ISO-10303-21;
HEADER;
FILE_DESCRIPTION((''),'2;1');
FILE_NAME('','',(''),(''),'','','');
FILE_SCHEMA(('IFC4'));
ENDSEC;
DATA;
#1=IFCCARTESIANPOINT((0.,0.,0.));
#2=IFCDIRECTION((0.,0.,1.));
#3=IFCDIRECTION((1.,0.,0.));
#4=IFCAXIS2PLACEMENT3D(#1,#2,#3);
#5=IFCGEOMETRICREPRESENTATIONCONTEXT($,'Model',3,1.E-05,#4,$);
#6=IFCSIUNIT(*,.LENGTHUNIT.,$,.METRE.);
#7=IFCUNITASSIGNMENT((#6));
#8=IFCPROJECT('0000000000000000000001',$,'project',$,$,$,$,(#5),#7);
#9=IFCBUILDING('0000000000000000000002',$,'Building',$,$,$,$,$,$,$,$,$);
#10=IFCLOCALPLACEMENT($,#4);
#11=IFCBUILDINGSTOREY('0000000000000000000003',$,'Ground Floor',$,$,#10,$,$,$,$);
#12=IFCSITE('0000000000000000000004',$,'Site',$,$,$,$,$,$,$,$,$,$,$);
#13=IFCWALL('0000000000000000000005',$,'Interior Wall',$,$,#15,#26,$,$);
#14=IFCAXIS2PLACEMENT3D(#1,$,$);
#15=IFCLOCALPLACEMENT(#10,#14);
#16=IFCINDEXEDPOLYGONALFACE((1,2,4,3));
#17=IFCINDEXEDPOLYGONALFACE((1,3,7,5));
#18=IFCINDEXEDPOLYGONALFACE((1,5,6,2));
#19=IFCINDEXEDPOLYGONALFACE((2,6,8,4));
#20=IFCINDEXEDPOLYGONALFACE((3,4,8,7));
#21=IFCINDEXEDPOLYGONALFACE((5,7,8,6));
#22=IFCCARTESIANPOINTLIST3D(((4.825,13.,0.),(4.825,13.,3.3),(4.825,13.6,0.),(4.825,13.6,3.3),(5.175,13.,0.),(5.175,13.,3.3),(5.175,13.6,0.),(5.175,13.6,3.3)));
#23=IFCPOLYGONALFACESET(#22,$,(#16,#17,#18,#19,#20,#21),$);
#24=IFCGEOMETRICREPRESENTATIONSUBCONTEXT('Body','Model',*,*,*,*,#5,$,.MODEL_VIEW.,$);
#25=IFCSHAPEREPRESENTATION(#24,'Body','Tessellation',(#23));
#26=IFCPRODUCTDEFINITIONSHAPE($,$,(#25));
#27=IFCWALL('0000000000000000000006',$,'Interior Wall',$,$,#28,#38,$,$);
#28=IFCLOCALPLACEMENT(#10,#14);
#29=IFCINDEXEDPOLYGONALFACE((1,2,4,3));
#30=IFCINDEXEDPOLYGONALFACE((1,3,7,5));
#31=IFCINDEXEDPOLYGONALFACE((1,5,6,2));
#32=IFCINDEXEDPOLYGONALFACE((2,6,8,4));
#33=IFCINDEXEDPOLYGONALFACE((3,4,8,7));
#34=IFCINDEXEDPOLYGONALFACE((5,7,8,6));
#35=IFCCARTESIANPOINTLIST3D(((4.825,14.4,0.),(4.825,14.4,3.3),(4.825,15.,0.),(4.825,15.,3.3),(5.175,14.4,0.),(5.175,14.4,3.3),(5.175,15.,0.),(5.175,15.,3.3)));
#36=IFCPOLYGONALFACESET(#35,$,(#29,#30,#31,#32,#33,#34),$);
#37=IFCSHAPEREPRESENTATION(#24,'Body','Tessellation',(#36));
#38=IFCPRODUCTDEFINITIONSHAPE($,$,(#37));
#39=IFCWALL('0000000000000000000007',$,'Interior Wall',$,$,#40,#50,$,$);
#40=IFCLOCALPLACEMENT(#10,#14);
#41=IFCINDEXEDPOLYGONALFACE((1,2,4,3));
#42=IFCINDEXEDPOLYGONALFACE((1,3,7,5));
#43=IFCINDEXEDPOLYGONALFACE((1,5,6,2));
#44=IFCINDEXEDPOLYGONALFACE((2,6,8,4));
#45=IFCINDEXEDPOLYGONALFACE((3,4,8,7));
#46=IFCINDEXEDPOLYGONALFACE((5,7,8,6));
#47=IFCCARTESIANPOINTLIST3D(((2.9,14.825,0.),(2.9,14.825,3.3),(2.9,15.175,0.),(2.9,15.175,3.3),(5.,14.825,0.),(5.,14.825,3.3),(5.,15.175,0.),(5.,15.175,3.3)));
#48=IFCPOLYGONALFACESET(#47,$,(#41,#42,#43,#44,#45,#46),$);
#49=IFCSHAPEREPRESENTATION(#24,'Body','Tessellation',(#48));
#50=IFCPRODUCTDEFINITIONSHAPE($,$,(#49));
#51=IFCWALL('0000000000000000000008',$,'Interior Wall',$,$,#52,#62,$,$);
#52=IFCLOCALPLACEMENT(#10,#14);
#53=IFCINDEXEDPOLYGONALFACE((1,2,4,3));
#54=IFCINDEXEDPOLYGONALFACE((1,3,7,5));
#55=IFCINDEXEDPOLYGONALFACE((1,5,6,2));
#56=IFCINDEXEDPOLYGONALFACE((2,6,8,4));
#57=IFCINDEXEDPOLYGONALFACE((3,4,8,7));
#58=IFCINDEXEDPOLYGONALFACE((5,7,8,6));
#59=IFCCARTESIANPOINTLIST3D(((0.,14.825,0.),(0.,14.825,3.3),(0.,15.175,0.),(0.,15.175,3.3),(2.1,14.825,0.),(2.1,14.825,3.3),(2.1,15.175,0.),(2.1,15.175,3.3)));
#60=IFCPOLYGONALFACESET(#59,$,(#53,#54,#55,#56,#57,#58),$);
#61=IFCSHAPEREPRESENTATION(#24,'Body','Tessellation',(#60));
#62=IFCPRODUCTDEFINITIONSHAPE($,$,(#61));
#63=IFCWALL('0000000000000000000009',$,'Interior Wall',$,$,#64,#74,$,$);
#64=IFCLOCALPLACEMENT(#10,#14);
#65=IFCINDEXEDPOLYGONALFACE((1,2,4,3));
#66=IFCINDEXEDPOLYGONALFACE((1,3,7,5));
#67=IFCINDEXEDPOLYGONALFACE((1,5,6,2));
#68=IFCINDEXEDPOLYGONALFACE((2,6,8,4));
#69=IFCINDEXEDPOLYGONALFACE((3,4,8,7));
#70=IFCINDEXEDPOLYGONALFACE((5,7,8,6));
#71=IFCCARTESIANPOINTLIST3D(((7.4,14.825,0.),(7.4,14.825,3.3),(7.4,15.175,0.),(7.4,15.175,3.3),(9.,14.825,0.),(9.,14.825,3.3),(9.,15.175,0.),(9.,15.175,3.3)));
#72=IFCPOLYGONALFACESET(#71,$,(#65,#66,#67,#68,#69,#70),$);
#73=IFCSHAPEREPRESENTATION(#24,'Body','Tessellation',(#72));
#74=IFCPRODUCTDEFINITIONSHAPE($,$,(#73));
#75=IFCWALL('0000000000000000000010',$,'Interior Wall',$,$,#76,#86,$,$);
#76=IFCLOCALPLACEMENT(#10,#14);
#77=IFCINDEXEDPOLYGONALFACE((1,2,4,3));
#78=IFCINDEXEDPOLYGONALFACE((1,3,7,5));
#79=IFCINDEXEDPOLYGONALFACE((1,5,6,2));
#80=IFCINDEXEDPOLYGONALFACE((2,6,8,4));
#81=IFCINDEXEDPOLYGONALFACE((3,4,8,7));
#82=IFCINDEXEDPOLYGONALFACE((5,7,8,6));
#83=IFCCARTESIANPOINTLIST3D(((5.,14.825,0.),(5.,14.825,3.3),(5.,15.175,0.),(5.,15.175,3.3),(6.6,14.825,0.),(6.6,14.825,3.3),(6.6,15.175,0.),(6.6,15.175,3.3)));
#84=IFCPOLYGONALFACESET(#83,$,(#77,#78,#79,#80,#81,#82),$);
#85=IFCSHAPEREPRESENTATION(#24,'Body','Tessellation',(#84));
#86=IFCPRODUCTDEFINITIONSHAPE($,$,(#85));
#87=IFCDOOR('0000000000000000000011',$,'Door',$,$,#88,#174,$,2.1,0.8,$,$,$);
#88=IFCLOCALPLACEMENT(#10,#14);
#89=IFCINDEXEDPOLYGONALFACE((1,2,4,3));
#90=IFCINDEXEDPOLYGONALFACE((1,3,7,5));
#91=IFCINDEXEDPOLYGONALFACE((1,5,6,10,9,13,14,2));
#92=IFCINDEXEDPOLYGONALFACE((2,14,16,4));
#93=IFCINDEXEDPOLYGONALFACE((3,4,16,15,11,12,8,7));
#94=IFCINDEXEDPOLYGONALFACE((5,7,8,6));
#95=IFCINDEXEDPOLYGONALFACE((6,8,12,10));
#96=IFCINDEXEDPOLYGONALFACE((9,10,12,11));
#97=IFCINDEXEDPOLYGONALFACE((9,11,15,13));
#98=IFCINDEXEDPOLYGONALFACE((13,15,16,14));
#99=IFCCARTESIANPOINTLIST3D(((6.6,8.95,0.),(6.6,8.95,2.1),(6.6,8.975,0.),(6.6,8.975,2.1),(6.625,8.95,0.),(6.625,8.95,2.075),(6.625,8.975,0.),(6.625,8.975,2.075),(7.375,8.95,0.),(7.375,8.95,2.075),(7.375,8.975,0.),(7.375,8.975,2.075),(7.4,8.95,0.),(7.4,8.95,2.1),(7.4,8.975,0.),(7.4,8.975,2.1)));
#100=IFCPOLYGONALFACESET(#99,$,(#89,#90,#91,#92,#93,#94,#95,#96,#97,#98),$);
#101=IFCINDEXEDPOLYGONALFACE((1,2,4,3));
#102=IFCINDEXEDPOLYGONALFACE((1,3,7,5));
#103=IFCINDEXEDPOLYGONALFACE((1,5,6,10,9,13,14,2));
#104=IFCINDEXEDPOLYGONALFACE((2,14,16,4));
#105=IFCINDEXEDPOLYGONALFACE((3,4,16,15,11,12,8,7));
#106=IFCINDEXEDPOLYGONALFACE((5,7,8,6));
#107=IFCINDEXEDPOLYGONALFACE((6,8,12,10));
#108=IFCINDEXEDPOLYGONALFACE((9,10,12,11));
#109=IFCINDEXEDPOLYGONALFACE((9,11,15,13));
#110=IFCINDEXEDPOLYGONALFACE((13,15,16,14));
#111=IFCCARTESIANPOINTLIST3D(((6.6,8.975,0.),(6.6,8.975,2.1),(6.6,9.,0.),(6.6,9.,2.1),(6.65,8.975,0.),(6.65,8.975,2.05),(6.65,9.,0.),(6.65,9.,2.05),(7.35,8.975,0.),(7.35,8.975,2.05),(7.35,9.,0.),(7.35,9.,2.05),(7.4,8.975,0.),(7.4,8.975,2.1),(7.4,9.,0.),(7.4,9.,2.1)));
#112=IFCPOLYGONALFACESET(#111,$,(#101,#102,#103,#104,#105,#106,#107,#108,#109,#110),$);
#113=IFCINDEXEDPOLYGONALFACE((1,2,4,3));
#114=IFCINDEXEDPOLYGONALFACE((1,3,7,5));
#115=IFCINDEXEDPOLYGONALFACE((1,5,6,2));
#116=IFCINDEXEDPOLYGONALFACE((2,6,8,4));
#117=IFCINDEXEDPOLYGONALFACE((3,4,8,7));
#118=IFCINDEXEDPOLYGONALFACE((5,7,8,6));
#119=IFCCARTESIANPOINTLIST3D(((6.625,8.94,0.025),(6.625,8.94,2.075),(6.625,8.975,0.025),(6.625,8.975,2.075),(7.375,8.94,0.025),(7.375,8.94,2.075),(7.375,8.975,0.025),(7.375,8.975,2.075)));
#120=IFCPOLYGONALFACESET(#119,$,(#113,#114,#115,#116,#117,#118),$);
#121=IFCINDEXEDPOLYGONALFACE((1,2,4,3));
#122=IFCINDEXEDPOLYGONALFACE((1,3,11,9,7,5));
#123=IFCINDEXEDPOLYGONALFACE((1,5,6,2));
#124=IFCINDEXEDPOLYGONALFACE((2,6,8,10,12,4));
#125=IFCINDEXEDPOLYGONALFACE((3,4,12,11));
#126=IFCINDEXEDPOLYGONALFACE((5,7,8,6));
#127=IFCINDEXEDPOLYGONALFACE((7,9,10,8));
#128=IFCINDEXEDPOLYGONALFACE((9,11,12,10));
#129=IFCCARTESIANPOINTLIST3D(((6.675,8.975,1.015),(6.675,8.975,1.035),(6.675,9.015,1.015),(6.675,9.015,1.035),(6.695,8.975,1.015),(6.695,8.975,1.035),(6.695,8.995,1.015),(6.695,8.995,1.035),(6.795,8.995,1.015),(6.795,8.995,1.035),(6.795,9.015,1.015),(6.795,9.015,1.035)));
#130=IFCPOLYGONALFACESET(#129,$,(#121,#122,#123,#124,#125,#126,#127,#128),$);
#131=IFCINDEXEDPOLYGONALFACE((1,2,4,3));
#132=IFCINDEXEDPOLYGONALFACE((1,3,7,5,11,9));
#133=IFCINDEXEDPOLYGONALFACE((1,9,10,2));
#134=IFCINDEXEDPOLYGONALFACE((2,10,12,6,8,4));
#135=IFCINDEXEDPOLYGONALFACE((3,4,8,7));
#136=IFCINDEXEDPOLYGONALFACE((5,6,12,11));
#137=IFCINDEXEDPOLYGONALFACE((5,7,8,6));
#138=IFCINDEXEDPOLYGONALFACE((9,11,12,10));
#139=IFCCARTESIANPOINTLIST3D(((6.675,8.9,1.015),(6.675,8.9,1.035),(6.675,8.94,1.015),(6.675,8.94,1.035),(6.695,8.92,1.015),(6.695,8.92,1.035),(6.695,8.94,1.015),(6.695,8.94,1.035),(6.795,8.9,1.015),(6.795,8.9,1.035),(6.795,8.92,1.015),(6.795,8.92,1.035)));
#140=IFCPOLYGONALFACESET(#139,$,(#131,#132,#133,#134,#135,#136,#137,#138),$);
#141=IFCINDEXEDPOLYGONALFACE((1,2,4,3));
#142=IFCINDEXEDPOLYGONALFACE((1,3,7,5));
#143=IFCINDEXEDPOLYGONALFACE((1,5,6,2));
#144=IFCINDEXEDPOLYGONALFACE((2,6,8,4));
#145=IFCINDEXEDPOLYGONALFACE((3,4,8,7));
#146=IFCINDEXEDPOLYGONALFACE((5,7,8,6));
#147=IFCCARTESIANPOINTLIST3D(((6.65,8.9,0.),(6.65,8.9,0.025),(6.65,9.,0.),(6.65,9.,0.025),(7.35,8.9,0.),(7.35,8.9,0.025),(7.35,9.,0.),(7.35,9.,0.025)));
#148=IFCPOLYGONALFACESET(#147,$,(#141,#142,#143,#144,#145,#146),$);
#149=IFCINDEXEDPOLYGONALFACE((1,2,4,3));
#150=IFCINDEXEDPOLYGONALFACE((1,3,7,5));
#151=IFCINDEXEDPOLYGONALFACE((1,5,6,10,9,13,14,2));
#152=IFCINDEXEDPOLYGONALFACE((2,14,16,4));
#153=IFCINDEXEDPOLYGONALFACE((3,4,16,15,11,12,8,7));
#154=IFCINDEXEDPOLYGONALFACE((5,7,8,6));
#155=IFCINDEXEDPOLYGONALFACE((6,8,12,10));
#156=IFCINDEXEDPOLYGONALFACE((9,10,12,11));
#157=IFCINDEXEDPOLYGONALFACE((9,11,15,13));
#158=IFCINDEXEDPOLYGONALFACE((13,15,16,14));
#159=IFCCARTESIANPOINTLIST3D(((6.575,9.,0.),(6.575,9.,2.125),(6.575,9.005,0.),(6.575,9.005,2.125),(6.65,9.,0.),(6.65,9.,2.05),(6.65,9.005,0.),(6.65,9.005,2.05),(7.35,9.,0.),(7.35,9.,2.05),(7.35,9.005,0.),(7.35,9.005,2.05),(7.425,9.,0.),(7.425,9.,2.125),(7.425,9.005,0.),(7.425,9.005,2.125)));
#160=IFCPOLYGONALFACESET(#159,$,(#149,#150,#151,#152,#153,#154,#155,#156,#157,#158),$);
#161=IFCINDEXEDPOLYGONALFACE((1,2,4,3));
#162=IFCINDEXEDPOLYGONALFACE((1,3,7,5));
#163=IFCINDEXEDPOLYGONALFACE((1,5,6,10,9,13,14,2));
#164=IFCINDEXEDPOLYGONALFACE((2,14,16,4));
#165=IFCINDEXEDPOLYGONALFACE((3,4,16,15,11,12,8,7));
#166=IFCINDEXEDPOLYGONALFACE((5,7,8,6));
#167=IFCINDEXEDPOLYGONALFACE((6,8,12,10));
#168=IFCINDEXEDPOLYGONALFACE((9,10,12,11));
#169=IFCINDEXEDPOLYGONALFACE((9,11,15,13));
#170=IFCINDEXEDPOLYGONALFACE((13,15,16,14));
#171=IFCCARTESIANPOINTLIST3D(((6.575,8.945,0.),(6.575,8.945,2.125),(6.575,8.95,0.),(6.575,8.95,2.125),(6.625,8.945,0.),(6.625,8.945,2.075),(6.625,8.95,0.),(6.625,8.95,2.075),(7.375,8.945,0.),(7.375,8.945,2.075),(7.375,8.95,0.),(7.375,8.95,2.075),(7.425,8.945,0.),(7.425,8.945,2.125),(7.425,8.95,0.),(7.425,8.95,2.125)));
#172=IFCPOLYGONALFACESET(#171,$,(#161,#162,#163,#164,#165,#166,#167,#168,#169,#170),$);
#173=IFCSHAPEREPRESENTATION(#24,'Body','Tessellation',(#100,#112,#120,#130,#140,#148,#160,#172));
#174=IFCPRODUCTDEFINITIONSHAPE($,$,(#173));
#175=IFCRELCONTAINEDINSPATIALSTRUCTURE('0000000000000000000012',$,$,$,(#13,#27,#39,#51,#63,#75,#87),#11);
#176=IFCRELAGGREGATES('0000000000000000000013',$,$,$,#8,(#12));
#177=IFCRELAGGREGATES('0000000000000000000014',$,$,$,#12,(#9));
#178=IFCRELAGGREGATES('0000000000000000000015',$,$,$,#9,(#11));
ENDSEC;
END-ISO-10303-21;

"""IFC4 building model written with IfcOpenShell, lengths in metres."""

from ifc_helpers import new_model, si_unit, frame, origin_with_axes, place, context, subcontext, project, spatial, line, indexed_curve, outline, extrude, element, save


model = new_model("IFC4")

# Units and contexts
model_context = context("Model", 3, precision=1e-05, world=origin_with_axes())
body_context = subcontext(model_context, "Body", "Model", "MODEL_VIEW")
ifc_project = project(units=[si_unit("LENGTHUNIT", "METRE")], contexts=[model_context])

# Site, building, storey
site = spatial("IfcSite", under=ifc_project, Name="Site")
building = spatial("IfcBuilding", under=site, Name="Building")
storey_placement = place(None, origin_with_axes())
storey = spatial("IfcBuildingStorey", under=building, at=storey_placement, Name="Ground Floor")

# Walls
for number, where, z_axis, x_axis, name in (
    (1, (5.0, 13.0, 0.0), (0.0, 0.0, 1.0), (0.0, 1.0, 0.0), "Interior Wall"),
    (2, (5.0, 14.4, 0.0), (0.0, 0.0, 1.0), (0.0, 1.0, 0.0), "Interior Wall"),
):
    element("IfcWall", number, at=place(storey_placement, frame(where, z_axis=z_axis, x_axis=x_axis)), inside=storey, Name=name, context=body_context, shape_type="SweptSolid", body=[
        extrude(outline(indexed_curve([(0.0, 0.0), (0.0, 0.35), (0.6, 0.35), (0.6, 0.0), (0.0, 0.0)], self_intersect=False)), frame((0.0, -0.175, 0.0), z_axis=(0.0, 0.0, 1.0), x_axis=(1.0, 0.0, 0.0)), (0.0, 0.0, 1.0), 3.3),
    ])
for number, where, z_axis, x_axis, name in (
    (3, (5.0, 15.0, 0.0), (0.0, 0.0, 1.0), (-1.0, 0.0, 0.0), "Interior Wall"),
    (4, (2.1, 15.0, 0.0), (0.0, 0.0, 1.0), (-1.0, 0.0, 0.0), "Interior Wall"),
):
    element("IfcWall", number, at=place(storey_placement, frame(where, z_axis=z_axis, x_axis=x_axis)), inside=storey, Name=name, context=body_context, shape_type="SweptSolid", body=[
        extrude(outline(indexed_curve([(0.0, 0.0), (0.0, 0.35), (2.1, 0.35), (2.1, 0.0), (0.0, 0.0)], self_intersect=False)), frame((0.0, -0.175, 0.0), z_axis=(0.0, 0.0, 1.0), x_axis=(1.0, 0.0, 0.0)), (0.0, 0.0, 1.0), 3.3),
    ])
for number, where, z_axis, x_axis, name in (
    (5, (9.0, 15.0, 0.0), (0.0, 0.0, 1.0), (-1.0, 0.0, 0.0), "Interior Wall"),
    (6, (6.6, 15.0, 0.0), (0.0, 0.0, 1.0), (-1.0, 0.0, 0.0), "Interior Wall"),
):
    element("IfcWall", number, at=place(storey_placement, frame(where, z_axis=z_axis, x_axis=x_axis)), inside=storey, Name=name, context=body_context, shape_type="SweptSolid", body=[
        extrude(outline(indexed_curve([(0.0, 0.0), (0.0, 0.35), (1.6, 0.35), (1.6, 0.0), (0.0, 0.0)], self_intersect=False)), frame((0.0, -0.175, 0.0), z_axis=(0.0, 0.0, 1.0), x_axis=(1.0, 0.0, 0.0)), (0.0, 0.0, 1.0), 3.3),
    ])

# Door
door_1_placement = place(storey_placement, frame((7.4, 9.0, 0.0), z_axis=(0.0, 0.0, 1.0), x_axis=(-1.0, 0.0, 0.0)))
element("IfcDoor", 7, at=door_1_placement, inside=storey, Name="Door", OverallHeight=2.1, OverallWidth=0.8, context=body_context, shape_type="SweptSolid", body=[
    extrude(outline(indexed_curve([(0.0, 0.0), (0.0, 2.1), (0.8, 2.1), (0.8, 0.0), (0.775, 0.0), (0.775, 2.075), (0.025, 2.075), (0.025, 0.0)], segments=[line(1, 2, 3, 4, 5, 6, 7, 8, 1)])), frame((0.0, 0.025, 0.0), z_axis=(0.0, -1.0, 0.0), x_axis=(1.0, 0.0, 0.0)), (0.0, 0.0, -1.0), 0.025),
    extrude(outline(indexed_curve([(0.0, 0.0), (0.0, 2.1), (0.8, 2.1), (0.8, 0.0), (0.75, 0.0), (0.75, 2.05), (0.05, 2.05), (0.05, 0.0)], segments=[line(1, 2, 3, 4, 5, 6, 7, 8, 1)])), frame((0.0, 0.0, 0.0), z_axis=(0.0, -1.0, 0.0), x_axis=(1.0, 0.0, 0.0)), (0.0, 0.0, -1.0), 0.025),
    extrude(outline(indexed_curve([(0.0, 0.0), (0.75, 0.0), (0.75, 0.035), (0.0, 0.035)], segments=[line(1, 2, 3, 4, 1)])), frame((0.025, 0.025, 0.025), z_axis=(0.0, 0.0, 1.0), x_axis=(1.0, 0.0, 0.0)), (0.0, 0.0, 1.0), 2.05),
    extrude(outline(indexed_curve([(0.0, 0.0), (0.0, -0.04), (-0.12, -0.04), (-0.12, -0.02), (-0.02, -0.02), (-0.02, 0.0)], segments=[line(1, 2, 3, 4, 5, 6, 1)])), frame((0.725, 0.025, 1.015), z_axis=(0.0, 0.0, 1.0), x_axis=(1.0, 0.0, 0.0)), (0.0, 0.0, 1.0), 0.02),
    extrude(outline(indexed_curve([(0.0, 0.0), (0.0, 0.04), (-0.12, 0.04), (-0.12, 0.02), (-0.02, 0.02), (-0.02, 0.0)], segments=[line(1, 2, 3, 4, 5, 6, 1)])), frame((0.725, 0.06, 1.015), z_axis=(0.0, 0.0, 1.0), x_axis=(1.0, 0.0, 0.0)), (0.0, 0.0, 1.0), 0.02),
    extrude(outline(indexed_curve([(0.0, 0.0), (0.7, 0.0), (0.7, 0.1), (0.0, 0.1)], segments=[line(1, 2, 3, 4, 1)])), frame((0.05, 0.0, 0.0), z_axis=(0.0, 0.0, 1.0), x_axis=(1.0, 0.0, 0.0)), (0.0, 0.0, 1.0), 0.025),
    extrude(outline(indexed_curve([(0.0, 0.0), (0.0, 2.125), (0.85, 2.125), (0.85, 0.0), (0.775, 0.0), (0.775, 2.05), (0.075, 2.05), (0.075, 0.0)], segments=[line(1, 2, 3, 4, 5, 6, 7, 8, 1)])), frame((-0.025, -0.005, 0.0), z_axis=(0.0, -1.0, 0.0), x_axis=(1.0, 0.0, 0.0)), (0.0, 0.0, -1.0), 0.005),
    extrude(outline(indexed_curve([(0.0, 0.0), (0.0, 2.125), (0.85, 2.125), (0.85, 0.0), (0.8, 0.0), (0.8, 2.075), (0.05, 2.075), (0.05, 0.0)], segments=[line(1, 2, 3, 4, 5, 6, 7, 8, 1)])), frame((-0.025, 0.05, 0.0), z_axis=(0.0, -1.0, 0.0), x_axis=(1.0, 0.0, 0.0)), (0.0, 0.0, -1.0), 0.005),
])

save(model, "model.ifc")
